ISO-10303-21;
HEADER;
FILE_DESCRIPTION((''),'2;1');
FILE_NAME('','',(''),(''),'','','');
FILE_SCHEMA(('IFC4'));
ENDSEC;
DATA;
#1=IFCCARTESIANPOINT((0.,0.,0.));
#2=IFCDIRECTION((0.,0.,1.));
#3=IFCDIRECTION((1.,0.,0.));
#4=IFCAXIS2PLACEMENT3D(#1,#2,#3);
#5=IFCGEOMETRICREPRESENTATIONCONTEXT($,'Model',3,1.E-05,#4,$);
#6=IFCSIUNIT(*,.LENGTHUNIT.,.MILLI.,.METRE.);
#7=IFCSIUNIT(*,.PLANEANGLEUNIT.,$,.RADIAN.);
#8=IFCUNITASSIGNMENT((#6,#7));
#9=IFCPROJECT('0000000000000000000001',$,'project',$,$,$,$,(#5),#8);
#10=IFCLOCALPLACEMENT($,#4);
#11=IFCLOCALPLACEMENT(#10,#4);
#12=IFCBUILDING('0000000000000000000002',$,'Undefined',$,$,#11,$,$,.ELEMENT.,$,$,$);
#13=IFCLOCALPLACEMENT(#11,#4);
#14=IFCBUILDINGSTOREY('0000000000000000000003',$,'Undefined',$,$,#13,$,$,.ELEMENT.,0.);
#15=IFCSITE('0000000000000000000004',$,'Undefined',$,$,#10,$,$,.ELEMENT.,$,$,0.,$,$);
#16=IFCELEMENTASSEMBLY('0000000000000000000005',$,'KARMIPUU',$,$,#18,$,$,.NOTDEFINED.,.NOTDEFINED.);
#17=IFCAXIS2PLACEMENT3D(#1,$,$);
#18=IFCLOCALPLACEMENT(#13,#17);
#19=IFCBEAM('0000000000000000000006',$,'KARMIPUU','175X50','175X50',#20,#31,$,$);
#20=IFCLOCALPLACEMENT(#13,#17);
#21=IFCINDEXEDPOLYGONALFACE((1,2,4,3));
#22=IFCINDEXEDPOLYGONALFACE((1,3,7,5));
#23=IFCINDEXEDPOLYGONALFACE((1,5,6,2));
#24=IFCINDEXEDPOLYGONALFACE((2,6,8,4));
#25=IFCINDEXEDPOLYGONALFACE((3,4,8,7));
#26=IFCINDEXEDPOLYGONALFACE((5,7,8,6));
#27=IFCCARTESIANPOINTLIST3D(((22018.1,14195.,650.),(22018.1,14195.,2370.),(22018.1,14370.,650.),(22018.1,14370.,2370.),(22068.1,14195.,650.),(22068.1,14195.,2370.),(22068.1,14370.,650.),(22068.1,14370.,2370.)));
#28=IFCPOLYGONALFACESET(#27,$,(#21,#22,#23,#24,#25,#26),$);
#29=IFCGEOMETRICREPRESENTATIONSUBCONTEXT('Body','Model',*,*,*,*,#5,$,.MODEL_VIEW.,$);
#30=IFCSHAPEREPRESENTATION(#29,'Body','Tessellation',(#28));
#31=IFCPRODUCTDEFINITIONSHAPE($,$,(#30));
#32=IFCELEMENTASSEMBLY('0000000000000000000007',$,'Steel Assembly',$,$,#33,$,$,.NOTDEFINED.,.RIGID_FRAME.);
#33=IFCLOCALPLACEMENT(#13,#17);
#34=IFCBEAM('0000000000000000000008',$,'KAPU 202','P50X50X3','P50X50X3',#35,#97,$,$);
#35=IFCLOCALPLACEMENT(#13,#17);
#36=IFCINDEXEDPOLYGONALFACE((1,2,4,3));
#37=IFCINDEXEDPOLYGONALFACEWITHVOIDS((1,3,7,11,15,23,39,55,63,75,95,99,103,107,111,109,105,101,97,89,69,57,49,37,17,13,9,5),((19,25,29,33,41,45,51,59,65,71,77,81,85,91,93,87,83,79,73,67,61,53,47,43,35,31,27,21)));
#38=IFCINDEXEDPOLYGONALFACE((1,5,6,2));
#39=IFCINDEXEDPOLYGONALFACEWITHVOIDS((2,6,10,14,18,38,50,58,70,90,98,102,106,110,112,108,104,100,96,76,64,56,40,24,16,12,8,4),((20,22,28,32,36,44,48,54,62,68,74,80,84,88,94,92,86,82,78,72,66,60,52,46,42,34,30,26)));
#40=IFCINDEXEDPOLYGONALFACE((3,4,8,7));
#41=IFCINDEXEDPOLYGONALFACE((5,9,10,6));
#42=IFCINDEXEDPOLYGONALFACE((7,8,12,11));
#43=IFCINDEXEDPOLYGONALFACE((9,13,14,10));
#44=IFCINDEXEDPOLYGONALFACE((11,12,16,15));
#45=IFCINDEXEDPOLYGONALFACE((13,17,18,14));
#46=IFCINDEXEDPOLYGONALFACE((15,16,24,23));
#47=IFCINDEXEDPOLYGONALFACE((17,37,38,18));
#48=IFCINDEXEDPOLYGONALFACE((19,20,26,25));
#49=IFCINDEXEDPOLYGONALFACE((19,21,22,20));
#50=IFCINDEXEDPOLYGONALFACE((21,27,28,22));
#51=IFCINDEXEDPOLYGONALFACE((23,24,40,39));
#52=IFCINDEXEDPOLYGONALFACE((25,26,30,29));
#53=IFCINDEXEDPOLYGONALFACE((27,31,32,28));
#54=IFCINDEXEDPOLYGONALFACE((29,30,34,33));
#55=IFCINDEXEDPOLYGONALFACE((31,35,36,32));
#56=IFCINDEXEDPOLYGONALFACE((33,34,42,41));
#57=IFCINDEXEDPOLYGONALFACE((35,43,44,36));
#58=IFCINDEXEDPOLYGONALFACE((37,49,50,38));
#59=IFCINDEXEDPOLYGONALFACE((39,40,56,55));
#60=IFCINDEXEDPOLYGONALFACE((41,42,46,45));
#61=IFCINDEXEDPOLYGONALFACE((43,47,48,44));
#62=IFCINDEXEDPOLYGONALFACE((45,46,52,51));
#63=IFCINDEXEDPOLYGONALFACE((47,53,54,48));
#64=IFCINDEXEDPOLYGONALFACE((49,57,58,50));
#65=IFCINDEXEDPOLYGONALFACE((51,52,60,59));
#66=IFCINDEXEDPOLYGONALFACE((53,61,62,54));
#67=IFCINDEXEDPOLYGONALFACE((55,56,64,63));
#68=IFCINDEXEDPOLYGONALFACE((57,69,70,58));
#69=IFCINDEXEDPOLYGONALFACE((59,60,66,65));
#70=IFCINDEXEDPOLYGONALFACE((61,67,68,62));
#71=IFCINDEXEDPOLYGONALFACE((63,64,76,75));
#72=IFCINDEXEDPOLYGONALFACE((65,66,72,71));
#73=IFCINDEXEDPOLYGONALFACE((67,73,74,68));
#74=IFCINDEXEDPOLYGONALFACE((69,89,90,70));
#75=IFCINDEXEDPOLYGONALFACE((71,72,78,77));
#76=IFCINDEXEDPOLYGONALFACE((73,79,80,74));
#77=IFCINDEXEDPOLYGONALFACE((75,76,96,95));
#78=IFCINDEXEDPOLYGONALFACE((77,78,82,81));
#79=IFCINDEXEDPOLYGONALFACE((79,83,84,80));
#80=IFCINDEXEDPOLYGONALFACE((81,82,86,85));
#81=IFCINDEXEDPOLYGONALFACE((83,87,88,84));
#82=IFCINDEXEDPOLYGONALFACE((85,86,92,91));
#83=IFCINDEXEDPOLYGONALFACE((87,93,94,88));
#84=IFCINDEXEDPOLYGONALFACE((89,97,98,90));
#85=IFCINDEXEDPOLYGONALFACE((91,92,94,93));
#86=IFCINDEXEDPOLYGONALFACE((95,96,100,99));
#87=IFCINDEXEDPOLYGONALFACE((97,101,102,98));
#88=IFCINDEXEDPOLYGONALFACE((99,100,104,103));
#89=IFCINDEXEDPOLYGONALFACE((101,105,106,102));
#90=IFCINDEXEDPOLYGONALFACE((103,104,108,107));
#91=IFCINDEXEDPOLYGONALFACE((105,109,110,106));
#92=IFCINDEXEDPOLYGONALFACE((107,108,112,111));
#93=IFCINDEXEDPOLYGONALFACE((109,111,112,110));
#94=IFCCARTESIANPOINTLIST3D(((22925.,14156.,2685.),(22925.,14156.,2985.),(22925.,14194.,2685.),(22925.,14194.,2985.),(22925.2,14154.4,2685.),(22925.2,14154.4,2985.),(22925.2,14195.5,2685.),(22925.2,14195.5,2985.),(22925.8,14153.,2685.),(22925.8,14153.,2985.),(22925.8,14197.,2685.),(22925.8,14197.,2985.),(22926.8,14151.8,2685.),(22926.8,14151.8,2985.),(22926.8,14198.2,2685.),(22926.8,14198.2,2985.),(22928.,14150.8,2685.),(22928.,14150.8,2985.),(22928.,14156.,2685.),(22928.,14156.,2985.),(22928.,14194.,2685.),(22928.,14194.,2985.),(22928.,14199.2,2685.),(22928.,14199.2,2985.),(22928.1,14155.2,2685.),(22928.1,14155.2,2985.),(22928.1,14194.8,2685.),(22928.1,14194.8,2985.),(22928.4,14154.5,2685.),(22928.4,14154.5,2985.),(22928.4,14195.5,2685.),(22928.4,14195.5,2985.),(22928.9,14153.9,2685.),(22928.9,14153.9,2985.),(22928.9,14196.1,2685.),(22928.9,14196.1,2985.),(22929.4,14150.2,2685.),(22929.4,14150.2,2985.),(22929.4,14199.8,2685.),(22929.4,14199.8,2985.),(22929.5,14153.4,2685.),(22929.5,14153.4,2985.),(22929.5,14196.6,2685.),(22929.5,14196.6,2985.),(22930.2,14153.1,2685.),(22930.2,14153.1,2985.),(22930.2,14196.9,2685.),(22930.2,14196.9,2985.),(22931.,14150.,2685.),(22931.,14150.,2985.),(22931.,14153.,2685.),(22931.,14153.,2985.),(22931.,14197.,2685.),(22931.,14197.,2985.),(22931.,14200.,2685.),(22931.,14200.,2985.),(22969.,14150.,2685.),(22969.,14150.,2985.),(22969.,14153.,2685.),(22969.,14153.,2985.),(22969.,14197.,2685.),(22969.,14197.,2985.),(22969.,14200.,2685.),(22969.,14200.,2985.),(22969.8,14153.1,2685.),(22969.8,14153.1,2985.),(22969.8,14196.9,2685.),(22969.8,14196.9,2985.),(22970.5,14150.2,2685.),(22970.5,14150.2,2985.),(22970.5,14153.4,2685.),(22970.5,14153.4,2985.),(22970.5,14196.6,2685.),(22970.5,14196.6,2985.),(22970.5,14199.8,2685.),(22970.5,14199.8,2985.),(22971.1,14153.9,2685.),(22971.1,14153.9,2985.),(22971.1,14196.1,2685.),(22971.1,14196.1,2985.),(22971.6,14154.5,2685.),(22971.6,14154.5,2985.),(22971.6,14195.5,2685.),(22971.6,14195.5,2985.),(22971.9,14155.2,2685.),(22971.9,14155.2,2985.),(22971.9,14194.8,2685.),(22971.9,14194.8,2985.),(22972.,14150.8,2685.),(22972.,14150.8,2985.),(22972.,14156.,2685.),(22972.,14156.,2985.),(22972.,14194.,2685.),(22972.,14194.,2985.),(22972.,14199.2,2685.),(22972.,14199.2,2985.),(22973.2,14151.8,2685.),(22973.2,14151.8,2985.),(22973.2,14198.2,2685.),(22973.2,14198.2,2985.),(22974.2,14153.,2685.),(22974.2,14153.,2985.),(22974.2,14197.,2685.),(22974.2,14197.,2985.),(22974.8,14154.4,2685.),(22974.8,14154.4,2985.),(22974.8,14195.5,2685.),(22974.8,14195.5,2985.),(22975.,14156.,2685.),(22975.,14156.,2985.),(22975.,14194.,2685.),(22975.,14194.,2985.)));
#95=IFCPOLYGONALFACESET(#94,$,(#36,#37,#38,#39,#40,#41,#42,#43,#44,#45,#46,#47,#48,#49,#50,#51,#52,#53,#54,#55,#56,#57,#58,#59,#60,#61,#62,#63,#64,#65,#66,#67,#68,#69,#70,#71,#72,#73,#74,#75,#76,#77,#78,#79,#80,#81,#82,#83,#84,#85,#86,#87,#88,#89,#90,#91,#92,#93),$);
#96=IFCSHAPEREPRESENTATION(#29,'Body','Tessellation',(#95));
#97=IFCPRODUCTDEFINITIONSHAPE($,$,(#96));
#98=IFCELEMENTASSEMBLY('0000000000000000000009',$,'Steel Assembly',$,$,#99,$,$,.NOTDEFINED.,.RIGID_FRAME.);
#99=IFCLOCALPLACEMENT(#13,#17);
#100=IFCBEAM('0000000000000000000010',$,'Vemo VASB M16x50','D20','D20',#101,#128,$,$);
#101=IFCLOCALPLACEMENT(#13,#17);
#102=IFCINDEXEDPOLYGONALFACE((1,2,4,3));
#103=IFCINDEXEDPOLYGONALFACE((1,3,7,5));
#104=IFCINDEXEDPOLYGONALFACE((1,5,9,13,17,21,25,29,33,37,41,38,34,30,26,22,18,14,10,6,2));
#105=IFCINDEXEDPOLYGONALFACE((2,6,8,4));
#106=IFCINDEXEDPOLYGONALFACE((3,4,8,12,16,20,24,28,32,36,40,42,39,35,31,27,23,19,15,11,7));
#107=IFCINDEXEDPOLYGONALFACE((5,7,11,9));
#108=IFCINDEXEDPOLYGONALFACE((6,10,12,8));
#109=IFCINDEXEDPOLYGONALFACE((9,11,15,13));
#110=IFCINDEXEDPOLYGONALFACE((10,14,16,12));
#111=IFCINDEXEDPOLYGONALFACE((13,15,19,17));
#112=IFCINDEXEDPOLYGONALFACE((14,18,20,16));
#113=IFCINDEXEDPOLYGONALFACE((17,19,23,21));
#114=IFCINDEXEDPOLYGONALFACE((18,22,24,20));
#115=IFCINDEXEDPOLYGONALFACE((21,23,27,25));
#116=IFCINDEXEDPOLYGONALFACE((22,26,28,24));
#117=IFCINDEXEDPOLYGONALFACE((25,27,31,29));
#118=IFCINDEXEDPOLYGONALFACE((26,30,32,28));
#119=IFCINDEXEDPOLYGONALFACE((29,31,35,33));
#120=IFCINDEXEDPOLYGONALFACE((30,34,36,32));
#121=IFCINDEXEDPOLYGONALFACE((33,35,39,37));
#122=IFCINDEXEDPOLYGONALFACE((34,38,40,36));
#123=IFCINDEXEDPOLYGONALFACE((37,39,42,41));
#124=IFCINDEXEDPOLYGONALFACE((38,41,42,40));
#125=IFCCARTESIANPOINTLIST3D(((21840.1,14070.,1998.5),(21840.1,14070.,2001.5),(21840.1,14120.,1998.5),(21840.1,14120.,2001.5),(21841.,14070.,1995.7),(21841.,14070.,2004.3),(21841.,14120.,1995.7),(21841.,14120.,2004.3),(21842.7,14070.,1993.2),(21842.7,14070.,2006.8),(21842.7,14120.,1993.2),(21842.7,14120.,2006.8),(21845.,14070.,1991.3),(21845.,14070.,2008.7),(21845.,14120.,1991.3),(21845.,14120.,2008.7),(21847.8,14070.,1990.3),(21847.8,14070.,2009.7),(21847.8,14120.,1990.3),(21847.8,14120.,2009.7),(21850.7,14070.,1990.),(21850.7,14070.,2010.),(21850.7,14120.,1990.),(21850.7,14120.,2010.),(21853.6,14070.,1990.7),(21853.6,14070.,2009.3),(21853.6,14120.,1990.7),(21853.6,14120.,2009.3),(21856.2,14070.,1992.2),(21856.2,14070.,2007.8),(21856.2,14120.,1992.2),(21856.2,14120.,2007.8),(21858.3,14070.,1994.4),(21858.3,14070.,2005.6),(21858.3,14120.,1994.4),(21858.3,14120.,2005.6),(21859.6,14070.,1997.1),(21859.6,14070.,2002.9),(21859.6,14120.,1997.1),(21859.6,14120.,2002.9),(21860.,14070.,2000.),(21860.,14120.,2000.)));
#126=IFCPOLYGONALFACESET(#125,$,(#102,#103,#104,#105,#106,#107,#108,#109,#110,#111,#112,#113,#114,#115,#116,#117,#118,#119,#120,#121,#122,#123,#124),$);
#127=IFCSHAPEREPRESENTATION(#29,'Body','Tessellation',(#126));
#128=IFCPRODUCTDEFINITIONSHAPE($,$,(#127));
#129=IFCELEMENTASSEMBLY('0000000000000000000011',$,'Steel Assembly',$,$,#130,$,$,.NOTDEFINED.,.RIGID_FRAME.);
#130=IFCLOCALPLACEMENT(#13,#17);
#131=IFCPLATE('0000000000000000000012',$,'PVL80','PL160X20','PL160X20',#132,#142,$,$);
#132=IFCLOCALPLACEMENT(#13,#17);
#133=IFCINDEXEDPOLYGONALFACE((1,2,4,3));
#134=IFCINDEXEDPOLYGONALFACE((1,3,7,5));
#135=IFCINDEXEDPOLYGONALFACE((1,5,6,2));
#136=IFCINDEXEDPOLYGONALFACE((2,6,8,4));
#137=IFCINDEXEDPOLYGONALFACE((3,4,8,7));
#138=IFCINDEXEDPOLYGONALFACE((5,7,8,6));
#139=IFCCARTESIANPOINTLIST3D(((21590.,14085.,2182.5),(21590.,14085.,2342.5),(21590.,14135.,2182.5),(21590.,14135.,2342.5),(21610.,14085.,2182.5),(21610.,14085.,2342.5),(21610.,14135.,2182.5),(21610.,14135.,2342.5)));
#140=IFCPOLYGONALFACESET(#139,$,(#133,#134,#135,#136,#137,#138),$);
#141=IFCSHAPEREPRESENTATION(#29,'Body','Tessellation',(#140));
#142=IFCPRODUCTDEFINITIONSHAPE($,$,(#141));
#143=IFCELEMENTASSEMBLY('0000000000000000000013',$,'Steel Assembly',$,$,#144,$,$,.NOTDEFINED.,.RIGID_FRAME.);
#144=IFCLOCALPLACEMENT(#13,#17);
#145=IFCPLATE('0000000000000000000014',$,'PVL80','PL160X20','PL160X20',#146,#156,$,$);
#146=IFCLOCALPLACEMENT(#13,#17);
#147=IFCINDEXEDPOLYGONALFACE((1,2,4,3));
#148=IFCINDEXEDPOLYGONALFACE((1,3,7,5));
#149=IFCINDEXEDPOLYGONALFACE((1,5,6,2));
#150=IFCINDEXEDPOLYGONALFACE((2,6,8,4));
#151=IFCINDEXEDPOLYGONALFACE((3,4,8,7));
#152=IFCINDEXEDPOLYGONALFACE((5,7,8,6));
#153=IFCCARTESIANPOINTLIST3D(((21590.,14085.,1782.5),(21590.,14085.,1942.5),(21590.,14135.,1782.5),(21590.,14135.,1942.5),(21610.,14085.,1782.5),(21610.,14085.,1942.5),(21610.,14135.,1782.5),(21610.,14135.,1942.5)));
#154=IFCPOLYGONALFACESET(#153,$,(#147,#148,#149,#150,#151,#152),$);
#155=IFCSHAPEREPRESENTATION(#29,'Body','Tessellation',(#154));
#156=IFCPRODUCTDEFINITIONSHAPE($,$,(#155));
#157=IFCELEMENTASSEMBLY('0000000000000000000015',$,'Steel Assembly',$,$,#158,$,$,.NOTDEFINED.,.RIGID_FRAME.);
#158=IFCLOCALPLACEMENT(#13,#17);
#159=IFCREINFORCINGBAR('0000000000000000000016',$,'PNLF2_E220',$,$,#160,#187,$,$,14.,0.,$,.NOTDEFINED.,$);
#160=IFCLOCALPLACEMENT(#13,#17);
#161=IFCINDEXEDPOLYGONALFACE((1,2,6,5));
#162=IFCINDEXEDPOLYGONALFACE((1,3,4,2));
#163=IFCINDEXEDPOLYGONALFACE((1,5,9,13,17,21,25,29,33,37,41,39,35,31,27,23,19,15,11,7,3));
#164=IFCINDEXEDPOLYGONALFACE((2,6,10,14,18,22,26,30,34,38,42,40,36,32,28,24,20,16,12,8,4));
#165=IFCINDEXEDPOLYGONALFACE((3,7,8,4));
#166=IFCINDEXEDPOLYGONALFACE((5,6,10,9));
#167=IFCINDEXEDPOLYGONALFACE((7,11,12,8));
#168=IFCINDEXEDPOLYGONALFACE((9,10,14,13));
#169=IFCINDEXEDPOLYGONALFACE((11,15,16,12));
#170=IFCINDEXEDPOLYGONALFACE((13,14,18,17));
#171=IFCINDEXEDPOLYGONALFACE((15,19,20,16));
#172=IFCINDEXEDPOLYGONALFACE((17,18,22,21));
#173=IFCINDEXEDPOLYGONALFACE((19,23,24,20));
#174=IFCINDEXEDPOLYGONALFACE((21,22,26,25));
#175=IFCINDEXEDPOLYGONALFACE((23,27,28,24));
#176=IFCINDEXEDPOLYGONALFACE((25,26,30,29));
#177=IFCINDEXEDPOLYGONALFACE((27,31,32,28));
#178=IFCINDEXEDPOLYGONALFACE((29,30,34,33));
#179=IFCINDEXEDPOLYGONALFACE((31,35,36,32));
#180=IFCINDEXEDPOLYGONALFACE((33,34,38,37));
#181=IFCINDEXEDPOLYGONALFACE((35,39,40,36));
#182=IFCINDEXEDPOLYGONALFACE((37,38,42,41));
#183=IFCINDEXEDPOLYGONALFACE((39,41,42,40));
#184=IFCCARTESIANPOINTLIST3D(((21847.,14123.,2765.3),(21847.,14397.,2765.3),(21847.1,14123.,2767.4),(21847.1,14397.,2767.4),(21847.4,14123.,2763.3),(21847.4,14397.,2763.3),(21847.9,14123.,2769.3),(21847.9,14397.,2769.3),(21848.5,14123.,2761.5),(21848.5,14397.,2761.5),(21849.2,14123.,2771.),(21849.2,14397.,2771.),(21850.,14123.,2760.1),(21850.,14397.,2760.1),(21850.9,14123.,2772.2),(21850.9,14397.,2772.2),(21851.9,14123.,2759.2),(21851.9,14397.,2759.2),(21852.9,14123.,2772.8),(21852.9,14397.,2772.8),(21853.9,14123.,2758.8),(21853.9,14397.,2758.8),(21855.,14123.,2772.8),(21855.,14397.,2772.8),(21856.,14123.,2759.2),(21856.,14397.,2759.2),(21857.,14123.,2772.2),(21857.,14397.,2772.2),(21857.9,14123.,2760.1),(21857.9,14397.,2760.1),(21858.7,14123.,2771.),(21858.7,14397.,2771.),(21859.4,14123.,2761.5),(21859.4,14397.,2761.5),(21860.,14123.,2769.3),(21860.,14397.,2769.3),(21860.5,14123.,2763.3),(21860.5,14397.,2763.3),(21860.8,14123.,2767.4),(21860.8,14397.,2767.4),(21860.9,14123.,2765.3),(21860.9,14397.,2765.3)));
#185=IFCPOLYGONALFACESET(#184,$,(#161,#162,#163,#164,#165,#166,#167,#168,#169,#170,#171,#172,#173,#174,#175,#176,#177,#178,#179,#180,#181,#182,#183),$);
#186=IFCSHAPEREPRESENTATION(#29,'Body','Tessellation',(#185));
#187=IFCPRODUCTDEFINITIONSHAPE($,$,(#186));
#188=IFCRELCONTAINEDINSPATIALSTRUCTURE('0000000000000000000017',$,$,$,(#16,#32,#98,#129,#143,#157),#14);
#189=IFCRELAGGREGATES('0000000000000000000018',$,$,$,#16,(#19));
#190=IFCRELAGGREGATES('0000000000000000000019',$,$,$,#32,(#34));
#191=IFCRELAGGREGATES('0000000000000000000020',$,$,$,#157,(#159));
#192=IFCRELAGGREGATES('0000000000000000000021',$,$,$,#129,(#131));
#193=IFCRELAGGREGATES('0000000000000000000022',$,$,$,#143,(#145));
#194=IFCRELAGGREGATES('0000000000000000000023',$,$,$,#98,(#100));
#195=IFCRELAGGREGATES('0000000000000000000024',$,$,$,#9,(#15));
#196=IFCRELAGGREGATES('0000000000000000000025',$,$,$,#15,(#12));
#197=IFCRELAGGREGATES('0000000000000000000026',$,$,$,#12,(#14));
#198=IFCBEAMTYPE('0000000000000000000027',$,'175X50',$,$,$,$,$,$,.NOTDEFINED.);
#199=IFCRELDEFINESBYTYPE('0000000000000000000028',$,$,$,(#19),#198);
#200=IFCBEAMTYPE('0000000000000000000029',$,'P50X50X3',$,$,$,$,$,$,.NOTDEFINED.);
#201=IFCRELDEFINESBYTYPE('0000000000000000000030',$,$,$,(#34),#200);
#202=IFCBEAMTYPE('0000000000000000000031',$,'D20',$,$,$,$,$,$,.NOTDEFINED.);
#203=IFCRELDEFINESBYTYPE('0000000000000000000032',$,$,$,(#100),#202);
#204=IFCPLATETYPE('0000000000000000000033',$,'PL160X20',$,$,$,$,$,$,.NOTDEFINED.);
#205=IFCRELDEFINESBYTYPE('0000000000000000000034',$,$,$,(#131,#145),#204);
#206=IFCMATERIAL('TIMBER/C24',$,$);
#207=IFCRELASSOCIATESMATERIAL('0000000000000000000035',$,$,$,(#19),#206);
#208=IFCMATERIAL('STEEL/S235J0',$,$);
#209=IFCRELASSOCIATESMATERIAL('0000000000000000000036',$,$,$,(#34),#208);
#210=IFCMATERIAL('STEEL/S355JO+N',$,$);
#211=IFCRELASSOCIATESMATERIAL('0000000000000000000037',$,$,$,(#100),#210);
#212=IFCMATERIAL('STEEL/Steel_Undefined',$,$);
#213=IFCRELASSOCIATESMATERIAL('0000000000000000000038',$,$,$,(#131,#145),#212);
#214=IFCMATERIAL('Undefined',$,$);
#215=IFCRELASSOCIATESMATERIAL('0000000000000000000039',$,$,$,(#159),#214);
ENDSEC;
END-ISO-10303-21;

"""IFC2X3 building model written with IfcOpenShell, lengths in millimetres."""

from ifc_helpers import new_model, entity, si_unit, frame, origin_with_axes, origin_2d_with_axis, place, context, subcontext, project, spatial, polyline, rectangle, hollow_rectangle, circle, outline, extrude, source, transform, mapped, material, type_object, element, aggregate, save


model = new_model("IFC2X3")

# Units and contexts
model_context = context("Model", 3, precision=1e-05, world=origin_with_axes())
body_context = subcontext(model_context, "Body", "Model", "MODEL_VIEW")
ifc_project = project(units=[si_unit("LENGTHUNIT", "METRE", prefix="MILLI"), si_unit("PLANEANGLEUNIT", "RADIAN")], contexts=[model_context])

# Site, building, storey
site_placement = place(None, origin_with_axes())
site = spatial("IfcSite", under=ifc_project, at=site_placement, Name="Undefined", CompositionType="ELEMENT", RefElevation=0.0)
building_placement = place(site_placement, origin_with_axes())
building = spatial("IfcBuilding", under=site, at=building_placement, Name="Undefined", CompositionType="ELEMENT")
storey_placement = place(building_placement, origin_with_axes())
storey = spatial("IfcBuildingStorey", under=building, at=storey_placement, Name="Undefined", CompositionType="ELEMENT", Elevation=0.0)

# Element assemblies, beams
assembly_1_placement = place(storey_placement, origin_with_axes())
assembly_1 = element("IfcElementAssembly", 1, at=assembly_1_placement, inside=storey, Name="KARMIPUU", AssemblyPlace="NOTDEFINED", PredefinedType="NOTDEFINED")
ifc_material_1 = material(Name="TIMBER/C24")
beam_type_1 = type_object("IfcBeamType", Name="175X50", PredefinedType="NOTDEFINED")
beam_1_placement = place(assembly_1_placement, frame((22043.1, 14282.5, 2370.0), z_axis=(0.0, -1.0, 0.0), x_axis=(0.0, 0.0, -1.0)))
beam_1 = element("IfcBeam", 2, at=beam_1_placement, type_object=beam_type_1, material=ifc_material_1, Name="KARMIPUU", Description="175X50", ObjectType="175X50", context=body_context, shape_type="SweptSolid", body=[
    extrude(rectangle(XDim=50.0, YDim=175.0, at=origin_2d_with_axis()), frame((1720.0, 0.0, 0.0), z_axis=(-1.0, 0.0, 0.0), x_axis=(0.0, -1.0, 0.0)), (0.0, 0.0, 1.0), 1720.0),
])
aggregate(assembly_1, [beam_1])
assembly_2_placement = place(storey_placement, origin_with_axes())
assembly_2 = element("IfcElementAssembly", 3, at=assembly_2_placement, inside=storey, Name="Steel Assembly", AssemblyPlace="NOTDEFINED", PredefinedType="RIGID_FRAME")
ifc_material_2 = material(Name="STEEL/S235J0")
beam_type_2 = type_object("IfcBeamType", Name="P50X50X3", PredefinedType="NOTDEFINED")
beam_2_placement = place(assembly_2_placement, frame((22950.0, 14175.0, 2985.0), z_axis=(1.0, 0.0, 0.0), x_axis=(0.0, 0.0, -1.0)))
beam_2 = element("IfcBeam", 4, at=beam_2_placement, type_object=beam_type_2, material=ifc_material_2, Name="KAPU 202", Description="P50X50X3", ObjectType="P50X50X3", context=body_context, shape_type="SweptSolid", body=[
    extrude(hollow_rectangle(XDim=50.0, YDim=50.0, WallThickness=3.0, InnerFilletRadius=3.0, OuterFilletRadius=6.0, at=origin_2d_with_axis()), frame((300.0, 0.0, 0.0), z_axis=(-1.0, 0.0, 0.0), x_axis=(0.0, -1.0, 0.0)), (0.0, 0.0, 1.0), 300.0),
])
aggregate(assembly_2, [beam_2])
assembly_3_placement = place(storey_placement, origin_with_axes())
assembly_3 = element("IfcElementAssembly", 5, at=assembly_3_placement, inside=storey, Name="Steel Assembly", AssemblyPlace="NOTDEFINED", PredefinedType="RIGID_FRAME")
ifc_material_3 = material(Name="STEEL/S355JO+N")
beam_type_3 = type_object("IfcBeamType", Name="D20", PredefinedType="NOTDEFINED")
beam_3_placement = place(assembly_3_placement, frame((21850.0, 14070.0, 2000.0), z_axis=(0.0, 0.0, 1.0), x_axis=(0.0, 1.0, 0.0)))
beam_3 = element("IfcBeam", 6, at=beam_3_placement, type_object=beam_type_3, material=ifc_material_3, Name="Vemo VASB M16x50", Description="D20", ObjectType="D20", context=body_context, shape_type="SweptSolid", body=[
    extrude(circle(Radius=10.0, at=origin_2d_with_axis()), frame((50.0, 0.0, 0.0), z_axis=(-1.0, 0.0, 0.0), x_axis=(0.0, -1.0, 0.0)), (0.0, 0.0, 1.0), 50.0),
])

# Element assemblies, plates
assembly_4_placement = place(storey_placement, origin_with_axes())
assembly_4 = element("IfcElementAssembly", 7, at=assembly_4_placement, inside=storey, Name="Steel Assembly", AssemblyPlace="NOTDEFINED", PredefinedType="RIGID_FRAME")
ifc_material_4 = material(Name="STEEL/Steel_Undefined")
plate_type = type_object("IfcPlateType", Name="PL160X20", PredefinedType="NOTDEFINED")
plate_1_placement = place(assembly_4_placement, frame((21590.0, 14085.0, 2262.5), z_axis=(0.0, 0.0, -1.0), x_axis=(0.0, 1.0, 0.0)))
plate_1 = element("IfcPlate", 8, at=plate_1_placement, type_object=plate_type, material=ifc_material_4, Name="PVL80", Description="PL160X20", ObjectType="PL160X20", context=body_context, shape_type="SweptSolid", body=[
    extrude(outline(polyline([(0.0, 0.0), (50.0, 0.0), (50.0, 20.0), (0.0, 20.0), (0.0, 0.0)])), frame((0.0, 0.0, -80.0), z_axis=(0.0, 0.0, 1.0), x_axis=(1.0, 0.0, 0.0)), (0.0, 0.0, 1.0), 160.0),
])
assembly_5_placement = place(storey_placement, origin_with_axes())
assembly_5 = element("IfcElementAssembly", 9, at=assembly_5_placement, inside=storey, Name="Steel Assembly", AssemblyPlace="NOTDEFINED", PredefinedType="RIGID_FRAME")
plate_2_placement = place(assembly_5_placement, frame((21590.0, 14085.0, 1862.5), z_axis=(0.0, 0.0, -1.0), x_axis=(0.0, 1.0, 0.0)))
plate_2 = element("IfcPlate", 10, at=plate_2_placement, type_object=plate_type, material=ifc_material_4, Name="PVL80", Description="PL160X20", ObjectType="PL160X20", context=body_context, shape_type="SweptSolid", body=[
    extrude(outline(polyline([(0.0, 0.0), (50.0, 0.0), (50.0, 20.0), (0.0, 20.0), (0.0, 0.0)])), frame((0.0, 0.0, -80.0), z_axis=(0.0, 0.0, 1.0), x_axis=(1.0, 0.0, 0.0)), (0.0, 0.0, 1.0), 160.0),
])

# Element assembly, reinforcing bar
assembly_6_placement = place(storey_placement, origin_with_axes())
assembly_6 = element("IfcElementAssembly", 11, at=assembly_6_placement, inside=storey, Name="Steel Assembly", AssemblyPlace="NOTDEFINED", PredefinedType="RIGID_FRAME")
ifc_material_5 = material(Name="Undefined")
shared_shape_1 = source(origin_with_axes(), body_context, "Body", "AdvancedSweptSolid", [
    entity("IfcSweptDiskSolid", entity("IfcTrimmedCurve", entity("IfcLine", entity("IfcCartesianPoint", [0.0, 0.0, 0.0]), entity("IfcVector", entity("IfcDirection", [1.0, 0.0, 0.0]), 1.0)), [entity("IfcParameterValue", 0.0)], [entity("IfcParameterValue", 273.999267)], True, "PARAMETER"), 7.0, None, 0.0, 274.0),
])
reinforcing_bar_1_placement = place(assembly_6_placement, frame((21853.9, 14397.0, 2765.8), z_axis=(0.0, 0.0, -1.0), x_axis=(0.0, -1.0, 0.0)))
reinforcing_bar_1 = element("IfcReinforcingBar", 12, at=reinforcing_bar_1_placement, material=ifc_material_5, Name="PNLF2_E220", BarRole="NOTDEFINED", CrossSectionArea=0.0, NominalDiameter=14.0, context=body_context, shape_type="MappedRepresentation", body=[
    mapped(shared_shape_1, transform((0.0, 0.0, 0.0))),
])
aggregate(assembly_6, [reinforcing_bar_1])

aggregate(assembly_4, [plate_1])
aggregate(assembly_5, [plate_2])

aggregate(assembly_3, [beam_3])

save(model, "model.ifc")
